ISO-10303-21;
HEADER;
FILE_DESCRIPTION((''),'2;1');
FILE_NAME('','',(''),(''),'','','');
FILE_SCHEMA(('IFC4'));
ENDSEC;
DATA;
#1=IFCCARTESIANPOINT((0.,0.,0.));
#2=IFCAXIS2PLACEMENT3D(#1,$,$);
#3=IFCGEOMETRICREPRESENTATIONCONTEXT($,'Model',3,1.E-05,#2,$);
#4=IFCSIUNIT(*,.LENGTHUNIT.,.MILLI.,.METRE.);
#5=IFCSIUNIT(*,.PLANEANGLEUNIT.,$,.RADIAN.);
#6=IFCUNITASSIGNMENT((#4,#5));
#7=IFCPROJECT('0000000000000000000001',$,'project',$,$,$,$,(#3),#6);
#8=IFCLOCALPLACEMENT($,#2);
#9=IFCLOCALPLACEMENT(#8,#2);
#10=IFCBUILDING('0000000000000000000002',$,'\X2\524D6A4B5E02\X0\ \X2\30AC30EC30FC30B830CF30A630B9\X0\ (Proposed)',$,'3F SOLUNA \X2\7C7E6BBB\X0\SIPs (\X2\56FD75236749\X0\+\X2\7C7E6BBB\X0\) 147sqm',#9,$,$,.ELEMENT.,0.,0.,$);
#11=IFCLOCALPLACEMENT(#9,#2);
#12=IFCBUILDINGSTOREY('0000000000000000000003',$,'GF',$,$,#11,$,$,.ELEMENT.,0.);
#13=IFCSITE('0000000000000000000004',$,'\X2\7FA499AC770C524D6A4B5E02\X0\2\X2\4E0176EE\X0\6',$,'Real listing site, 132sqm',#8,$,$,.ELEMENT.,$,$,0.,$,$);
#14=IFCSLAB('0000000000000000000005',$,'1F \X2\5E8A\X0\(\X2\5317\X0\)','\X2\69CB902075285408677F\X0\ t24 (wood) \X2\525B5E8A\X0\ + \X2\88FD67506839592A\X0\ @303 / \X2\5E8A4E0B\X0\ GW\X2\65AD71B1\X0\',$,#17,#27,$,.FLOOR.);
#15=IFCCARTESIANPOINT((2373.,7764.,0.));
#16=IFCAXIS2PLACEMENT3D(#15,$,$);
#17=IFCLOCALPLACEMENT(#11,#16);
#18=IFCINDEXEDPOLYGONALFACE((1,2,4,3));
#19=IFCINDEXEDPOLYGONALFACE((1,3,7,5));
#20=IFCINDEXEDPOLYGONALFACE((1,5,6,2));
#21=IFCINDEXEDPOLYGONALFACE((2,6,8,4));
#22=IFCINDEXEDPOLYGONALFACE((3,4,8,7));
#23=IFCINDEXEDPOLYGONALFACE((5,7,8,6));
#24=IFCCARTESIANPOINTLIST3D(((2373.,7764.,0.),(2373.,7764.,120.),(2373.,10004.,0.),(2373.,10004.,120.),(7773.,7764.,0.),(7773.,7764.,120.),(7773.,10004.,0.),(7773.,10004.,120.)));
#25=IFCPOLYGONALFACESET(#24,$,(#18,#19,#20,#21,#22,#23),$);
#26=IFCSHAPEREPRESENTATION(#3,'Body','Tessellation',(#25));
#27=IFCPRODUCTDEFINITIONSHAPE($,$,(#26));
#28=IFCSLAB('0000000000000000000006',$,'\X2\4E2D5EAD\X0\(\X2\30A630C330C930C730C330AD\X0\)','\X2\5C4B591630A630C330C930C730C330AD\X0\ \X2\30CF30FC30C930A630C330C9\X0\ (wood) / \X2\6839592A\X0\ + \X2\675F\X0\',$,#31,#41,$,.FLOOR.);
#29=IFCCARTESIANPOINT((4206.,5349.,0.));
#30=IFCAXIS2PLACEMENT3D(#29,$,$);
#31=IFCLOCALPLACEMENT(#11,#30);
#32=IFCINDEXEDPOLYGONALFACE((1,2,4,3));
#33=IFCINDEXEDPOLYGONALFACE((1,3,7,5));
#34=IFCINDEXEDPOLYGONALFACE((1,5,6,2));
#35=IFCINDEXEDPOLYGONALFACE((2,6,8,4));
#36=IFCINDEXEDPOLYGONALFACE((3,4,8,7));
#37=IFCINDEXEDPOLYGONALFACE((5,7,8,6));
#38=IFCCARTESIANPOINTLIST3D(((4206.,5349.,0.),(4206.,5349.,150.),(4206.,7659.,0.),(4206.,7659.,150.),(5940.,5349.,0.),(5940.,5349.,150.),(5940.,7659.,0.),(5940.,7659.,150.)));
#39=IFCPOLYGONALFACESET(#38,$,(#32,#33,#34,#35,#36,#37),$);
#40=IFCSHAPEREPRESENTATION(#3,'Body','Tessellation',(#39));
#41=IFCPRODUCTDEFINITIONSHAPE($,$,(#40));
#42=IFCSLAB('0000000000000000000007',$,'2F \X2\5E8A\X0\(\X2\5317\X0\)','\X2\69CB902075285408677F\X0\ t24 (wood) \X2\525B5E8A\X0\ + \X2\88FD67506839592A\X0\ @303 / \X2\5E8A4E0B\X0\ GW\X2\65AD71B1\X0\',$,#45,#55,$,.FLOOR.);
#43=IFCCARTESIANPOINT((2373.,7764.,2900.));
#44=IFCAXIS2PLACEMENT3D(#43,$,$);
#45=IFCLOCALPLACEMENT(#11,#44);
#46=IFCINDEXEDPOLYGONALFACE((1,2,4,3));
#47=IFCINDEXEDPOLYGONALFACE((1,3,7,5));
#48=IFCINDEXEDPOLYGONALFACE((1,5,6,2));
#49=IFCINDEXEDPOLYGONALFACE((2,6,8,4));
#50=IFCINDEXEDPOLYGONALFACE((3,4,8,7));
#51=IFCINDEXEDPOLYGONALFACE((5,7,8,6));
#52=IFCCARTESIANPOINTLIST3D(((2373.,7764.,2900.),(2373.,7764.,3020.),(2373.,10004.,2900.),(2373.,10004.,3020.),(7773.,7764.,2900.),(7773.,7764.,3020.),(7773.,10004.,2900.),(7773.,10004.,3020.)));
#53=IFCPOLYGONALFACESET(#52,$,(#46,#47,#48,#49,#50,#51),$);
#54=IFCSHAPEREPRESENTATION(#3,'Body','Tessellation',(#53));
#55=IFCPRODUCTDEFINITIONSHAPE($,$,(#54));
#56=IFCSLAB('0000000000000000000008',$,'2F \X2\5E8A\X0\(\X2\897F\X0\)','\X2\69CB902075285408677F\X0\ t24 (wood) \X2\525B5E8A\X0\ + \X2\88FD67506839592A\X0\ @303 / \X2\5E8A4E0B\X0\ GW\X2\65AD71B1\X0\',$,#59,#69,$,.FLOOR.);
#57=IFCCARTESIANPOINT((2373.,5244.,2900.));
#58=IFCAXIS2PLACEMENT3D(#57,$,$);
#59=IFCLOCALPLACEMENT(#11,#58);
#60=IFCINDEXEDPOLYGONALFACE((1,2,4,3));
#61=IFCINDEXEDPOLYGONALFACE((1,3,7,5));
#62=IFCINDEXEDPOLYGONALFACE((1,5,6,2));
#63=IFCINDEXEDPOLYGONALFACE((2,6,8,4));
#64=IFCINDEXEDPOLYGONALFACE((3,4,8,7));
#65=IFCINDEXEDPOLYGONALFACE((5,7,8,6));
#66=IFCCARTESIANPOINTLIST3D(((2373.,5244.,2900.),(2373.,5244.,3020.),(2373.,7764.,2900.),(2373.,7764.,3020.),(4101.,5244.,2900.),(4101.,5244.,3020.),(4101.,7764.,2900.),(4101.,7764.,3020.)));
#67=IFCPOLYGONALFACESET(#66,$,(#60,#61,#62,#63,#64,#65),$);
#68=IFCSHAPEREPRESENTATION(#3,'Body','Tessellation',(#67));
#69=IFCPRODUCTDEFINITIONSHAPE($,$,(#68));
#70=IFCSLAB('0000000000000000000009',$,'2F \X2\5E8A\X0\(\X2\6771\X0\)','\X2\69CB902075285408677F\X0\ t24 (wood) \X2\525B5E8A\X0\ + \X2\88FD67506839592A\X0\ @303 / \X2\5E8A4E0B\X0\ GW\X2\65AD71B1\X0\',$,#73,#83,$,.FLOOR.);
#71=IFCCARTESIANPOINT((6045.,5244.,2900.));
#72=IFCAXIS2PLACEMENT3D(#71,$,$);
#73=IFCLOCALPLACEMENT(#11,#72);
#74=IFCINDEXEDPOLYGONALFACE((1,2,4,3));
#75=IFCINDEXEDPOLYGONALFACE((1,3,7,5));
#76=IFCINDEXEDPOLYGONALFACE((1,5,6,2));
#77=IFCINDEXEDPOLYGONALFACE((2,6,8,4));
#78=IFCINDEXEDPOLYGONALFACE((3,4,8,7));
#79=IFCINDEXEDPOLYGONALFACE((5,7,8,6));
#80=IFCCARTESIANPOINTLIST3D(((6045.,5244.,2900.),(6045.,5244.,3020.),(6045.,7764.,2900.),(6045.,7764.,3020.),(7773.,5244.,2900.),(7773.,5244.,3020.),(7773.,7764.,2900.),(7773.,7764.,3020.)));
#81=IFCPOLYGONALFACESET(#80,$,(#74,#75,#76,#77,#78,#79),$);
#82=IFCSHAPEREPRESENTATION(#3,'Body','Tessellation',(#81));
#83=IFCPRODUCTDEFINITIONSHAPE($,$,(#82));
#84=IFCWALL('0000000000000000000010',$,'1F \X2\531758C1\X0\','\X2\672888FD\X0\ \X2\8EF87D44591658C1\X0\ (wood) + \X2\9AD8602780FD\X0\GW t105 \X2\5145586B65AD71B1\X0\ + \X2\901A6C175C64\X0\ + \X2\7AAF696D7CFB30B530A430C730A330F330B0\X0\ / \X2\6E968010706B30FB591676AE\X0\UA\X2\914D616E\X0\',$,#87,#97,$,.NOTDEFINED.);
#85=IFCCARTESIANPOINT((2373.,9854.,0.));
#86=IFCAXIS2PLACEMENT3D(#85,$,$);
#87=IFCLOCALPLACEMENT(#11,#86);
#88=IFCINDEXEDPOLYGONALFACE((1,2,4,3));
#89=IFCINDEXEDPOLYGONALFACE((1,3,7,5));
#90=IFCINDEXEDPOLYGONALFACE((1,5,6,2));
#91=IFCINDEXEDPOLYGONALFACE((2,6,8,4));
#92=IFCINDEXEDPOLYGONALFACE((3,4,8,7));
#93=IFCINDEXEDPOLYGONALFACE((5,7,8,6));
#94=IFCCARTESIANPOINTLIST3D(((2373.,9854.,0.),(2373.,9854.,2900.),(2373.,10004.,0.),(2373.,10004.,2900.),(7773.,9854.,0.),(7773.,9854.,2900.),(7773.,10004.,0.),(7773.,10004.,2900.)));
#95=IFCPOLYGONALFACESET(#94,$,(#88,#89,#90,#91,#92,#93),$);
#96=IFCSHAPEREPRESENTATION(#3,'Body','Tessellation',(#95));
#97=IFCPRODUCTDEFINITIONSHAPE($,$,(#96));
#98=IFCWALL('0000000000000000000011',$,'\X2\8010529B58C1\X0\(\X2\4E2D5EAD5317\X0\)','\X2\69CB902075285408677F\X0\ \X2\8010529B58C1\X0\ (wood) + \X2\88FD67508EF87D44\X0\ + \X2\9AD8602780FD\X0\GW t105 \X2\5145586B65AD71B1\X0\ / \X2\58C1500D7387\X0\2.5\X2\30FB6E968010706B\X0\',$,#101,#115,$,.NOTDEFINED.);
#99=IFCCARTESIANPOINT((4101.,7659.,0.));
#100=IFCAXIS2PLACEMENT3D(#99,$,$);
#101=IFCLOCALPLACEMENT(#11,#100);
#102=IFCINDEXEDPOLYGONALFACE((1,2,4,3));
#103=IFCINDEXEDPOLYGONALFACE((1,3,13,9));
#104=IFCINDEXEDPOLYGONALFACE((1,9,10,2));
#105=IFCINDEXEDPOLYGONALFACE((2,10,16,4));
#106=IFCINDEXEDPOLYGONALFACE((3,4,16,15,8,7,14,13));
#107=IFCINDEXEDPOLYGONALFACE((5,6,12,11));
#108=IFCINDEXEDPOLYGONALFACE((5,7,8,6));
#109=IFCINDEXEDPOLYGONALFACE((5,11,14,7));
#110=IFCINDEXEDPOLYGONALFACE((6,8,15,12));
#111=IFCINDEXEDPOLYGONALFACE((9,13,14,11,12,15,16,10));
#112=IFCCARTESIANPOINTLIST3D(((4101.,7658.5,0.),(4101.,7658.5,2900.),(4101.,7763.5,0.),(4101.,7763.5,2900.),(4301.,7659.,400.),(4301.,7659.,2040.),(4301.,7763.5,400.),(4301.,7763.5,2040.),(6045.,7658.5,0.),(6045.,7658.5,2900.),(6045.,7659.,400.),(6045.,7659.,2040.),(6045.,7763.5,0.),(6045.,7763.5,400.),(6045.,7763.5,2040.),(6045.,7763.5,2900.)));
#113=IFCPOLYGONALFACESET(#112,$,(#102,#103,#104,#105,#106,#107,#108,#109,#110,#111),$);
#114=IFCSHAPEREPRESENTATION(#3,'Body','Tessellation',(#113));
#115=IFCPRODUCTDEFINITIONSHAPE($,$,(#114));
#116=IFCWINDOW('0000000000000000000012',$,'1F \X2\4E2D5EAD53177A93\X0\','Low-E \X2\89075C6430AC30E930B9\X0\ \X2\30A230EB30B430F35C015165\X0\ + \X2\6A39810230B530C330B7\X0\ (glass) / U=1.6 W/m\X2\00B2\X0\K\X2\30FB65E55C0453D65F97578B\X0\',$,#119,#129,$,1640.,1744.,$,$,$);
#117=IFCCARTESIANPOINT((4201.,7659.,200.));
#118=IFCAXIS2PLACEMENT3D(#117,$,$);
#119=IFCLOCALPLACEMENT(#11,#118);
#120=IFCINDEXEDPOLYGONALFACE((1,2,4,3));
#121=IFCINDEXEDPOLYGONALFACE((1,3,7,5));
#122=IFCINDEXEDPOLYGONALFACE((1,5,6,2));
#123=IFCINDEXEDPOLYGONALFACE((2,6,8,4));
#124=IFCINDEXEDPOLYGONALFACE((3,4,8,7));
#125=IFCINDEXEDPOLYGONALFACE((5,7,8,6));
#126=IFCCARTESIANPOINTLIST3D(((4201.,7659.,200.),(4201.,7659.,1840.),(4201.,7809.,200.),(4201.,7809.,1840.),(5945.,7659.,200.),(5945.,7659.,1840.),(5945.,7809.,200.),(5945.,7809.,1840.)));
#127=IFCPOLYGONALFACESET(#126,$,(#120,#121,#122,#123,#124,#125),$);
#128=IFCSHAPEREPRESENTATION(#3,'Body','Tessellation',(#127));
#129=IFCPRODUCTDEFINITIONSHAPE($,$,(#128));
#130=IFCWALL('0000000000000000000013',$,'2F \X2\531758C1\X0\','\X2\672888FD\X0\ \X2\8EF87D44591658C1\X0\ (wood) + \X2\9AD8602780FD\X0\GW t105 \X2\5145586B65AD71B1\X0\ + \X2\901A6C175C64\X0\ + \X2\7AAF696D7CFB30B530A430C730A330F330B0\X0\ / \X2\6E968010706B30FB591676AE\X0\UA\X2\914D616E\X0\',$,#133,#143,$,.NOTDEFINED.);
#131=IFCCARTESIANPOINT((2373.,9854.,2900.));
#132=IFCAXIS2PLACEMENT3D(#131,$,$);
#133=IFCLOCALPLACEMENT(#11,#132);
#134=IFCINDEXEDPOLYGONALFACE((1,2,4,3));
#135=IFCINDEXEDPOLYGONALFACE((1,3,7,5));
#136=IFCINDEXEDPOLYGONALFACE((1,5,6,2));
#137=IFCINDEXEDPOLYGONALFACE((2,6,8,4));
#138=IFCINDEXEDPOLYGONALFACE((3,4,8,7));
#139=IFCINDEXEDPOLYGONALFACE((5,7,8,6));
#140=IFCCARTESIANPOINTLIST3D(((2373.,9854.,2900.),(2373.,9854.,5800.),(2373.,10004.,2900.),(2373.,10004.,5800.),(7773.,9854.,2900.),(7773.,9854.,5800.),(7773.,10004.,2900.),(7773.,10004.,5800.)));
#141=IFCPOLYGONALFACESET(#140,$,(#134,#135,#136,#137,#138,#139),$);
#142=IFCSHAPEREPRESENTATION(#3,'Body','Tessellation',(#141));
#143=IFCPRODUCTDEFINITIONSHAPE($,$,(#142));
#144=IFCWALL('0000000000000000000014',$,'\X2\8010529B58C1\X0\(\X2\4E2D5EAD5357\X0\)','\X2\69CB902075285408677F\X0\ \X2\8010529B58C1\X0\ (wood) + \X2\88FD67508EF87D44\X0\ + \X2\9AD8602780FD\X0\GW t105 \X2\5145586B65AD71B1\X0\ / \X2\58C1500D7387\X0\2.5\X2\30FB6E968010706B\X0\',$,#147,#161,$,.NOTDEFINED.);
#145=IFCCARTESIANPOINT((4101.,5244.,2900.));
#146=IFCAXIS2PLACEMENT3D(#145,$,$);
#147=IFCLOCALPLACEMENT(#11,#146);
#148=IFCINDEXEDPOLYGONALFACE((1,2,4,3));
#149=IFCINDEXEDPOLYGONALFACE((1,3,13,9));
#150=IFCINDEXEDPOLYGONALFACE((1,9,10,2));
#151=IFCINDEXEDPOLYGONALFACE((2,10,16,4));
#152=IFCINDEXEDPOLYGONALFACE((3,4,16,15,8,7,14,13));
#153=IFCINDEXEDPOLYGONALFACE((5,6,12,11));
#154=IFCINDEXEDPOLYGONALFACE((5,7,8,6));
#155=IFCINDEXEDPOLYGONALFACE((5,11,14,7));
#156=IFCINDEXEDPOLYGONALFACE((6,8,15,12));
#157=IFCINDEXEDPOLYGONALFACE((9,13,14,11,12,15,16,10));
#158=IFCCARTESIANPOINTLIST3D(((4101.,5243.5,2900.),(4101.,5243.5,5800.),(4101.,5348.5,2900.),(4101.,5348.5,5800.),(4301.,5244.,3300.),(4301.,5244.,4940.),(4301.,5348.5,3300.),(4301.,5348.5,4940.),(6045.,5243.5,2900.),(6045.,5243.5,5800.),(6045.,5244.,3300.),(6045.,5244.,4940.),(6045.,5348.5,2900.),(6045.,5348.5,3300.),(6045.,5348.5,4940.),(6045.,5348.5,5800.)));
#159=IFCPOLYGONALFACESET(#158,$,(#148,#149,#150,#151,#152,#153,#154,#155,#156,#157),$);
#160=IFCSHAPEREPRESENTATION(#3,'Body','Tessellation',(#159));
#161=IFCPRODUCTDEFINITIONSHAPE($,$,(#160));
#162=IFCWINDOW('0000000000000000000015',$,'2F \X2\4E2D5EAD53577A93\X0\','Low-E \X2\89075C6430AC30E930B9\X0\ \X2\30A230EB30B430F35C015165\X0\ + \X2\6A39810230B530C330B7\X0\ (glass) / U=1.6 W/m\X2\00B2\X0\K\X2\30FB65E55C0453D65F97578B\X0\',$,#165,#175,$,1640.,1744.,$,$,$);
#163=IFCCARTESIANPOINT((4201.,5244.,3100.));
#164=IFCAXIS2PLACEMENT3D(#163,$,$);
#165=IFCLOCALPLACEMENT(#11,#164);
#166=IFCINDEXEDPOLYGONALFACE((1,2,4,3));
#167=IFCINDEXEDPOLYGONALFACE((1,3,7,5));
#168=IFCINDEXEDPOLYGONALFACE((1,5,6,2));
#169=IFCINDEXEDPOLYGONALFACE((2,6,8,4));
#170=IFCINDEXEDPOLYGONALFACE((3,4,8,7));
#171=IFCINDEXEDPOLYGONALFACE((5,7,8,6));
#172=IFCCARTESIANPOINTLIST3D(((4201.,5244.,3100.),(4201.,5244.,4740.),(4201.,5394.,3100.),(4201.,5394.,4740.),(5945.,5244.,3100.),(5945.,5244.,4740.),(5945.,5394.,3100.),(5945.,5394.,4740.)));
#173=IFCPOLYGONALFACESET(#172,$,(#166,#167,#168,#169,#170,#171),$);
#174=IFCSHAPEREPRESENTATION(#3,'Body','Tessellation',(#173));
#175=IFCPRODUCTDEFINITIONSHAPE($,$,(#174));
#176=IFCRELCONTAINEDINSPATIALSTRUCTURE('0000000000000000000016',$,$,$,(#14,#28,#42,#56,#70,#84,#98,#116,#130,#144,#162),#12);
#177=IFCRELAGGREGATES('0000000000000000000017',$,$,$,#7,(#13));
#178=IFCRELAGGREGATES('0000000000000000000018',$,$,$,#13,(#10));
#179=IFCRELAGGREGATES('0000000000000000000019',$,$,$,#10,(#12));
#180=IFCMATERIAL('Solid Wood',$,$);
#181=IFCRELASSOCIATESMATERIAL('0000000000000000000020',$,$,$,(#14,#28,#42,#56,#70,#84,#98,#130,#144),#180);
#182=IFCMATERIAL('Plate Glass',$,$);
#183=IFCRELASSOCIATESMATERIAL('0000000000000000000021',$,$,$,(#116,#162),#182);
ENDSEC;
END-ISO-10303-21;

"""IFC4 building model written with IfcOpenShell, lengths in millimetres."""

from ifc_helpers import new_model, si_unit, frame, frame_2d, origin, place, context, project, spatial, rectangle, extrude, material, element, fill, save


model = new_model("IFC4")

# Units and contexts
model_context = context("Model", 3, precision=1e-05, world=origin())
ifc_project = project(units=[si_unit("LENGTHUNIT", "METRE", prefix="MILLI"), si_unit("PLANEANGLEUNIT", "RADIAN")], contexts=[model_context])

# Site, building, storey
site_placement = place(None, origin())
site = spatial("IfcSite", under=ifc_project, at=site_placement, Name="群馬県前橋市2丁目6", ObjectType="Real listing site, 132sqm", CompositionType="ELEMENT", RefElevation=0.0)
building_placement = place(site_placement, origin())
building = spatial("IfcBuilding", under=site, at=building_placement, Name="前橋市 ガレージハウス (Proposed)", ObjectType="3F SOLUNA 籾殻SIPs (国産杉+籾殻) 147sqm", CompositionType="ELEMENT", ElevationOfRefHeight=0.0, ElevationOfTerrain=0.0)
storey_placement = place(building_placement, origin())
storey = spatial("IfcBuildingStorey", under=building, at=storey_placement, Name="GF", CompositionType="ELEMENT", Elevation=0.0)

# Slabs
ifc_material_1 = material(Name="Solid Wood")
slab_1_placement = place(storey_placement, frame((2373.0, 7764.0, 0.0)))
element("IfcSlab", 1, at=slab_1_placement, inside=storey, material=ifc_material_1, Name="1F 床(北)", Description="構造用合板 t24 (wood) 剛床 + 製材根太 @303 / 床下 GW断熱", PredefinedType="FLOOR", context=model_context, shape_type="SweptSolid", body=[
    extrude(rectangle(XDim=5400.0, YDim=2240.0, at=frame_2d((2700.0, 1120.0))), frame((2373.0, 7764.0, 0.0)), (0.0, 0.0, 1.0), 120.0),
])
slab_2_placement = place(storey_placement, frame((4206.0, 5349.0, 0.0)))
element("IfcSlab", 2, at=slab_2_placement, inside=storey, material=ifc_material_1, Name="中庭(ウッドデッキ)", Description="屋外ウッドデッキ ハードウッド (wood) / 根太 + 束", PredefinedType="FLOOR", context=model_context, shape_type="SweptSolid", body=[
    extrude(rectangle(XDim=1734.0, YDim=2310.0, at=frame_2d((867.0, 1155.0))), frame((4206.0, 5349.0, 0.0)), (0.0, 0.0, 1.0), 150.0),
])
slab_3_placement = place(storey_placement, frame((2373.0, 7764.0, 2900.0)))
element("IfcSlab", 3, at=slab_3_placement, inside=storey, material=ifc_material_1, Name="2F 床(北)", Description="構造用合板 t24 (wood) 剛床 + 製材根太 @303 / 床下 GW断熱", PredefinedType="FLOOR", context=model_context, shape_type="SweptSolid", body=[
    extrude(rectangle(XDim=5400.0, YDim=2240.0, at=frame_2d((2700.0, 1120.0))), frame((2373.0, 7764.0, 2900.0)), (0.0, 0.0, 1.0), 120.0),
])
slab_4_placement = place(storey_placement, frame((2373.0, 5244.0, 2900.0)))
element("IfcSlab", 4, at=slab_4_placement, inside=storey, material=ifc_material_1, Name="2F 床(西)", Description="構造用合板 t24 (wood) 剛床 + 製材根太 @303 / 床下 GW断熱", PredefinedType="FLOOR", context=model_context, shape_type="SweptSolid", body=[
    extrude(rectangle(XDim=1728.0, YDim=2520.0, at=frame_2d((864.0, 1260.0))), frame((2373.0, 5244.0, 2900.0)), (0.0, 0.0, 1.0), 120.0),
])
slab_5_placement = place(storey_placement, frame((6045.0, 5244.0, 2900.0)))
element("IfcSlab", 5, at=slab_5_placement, inside=storey, material=ifc_material_1, Name="2F 床(東)", Description="構造用合板 t24 (wood) 剛床 + 製材根太 @303 / 床下 GW断熱", PredefinedType="FLOOR", context=model_context, shape_type="SweptSolid", body=[
    extrude(rectangle(XDim=1728.0, YDim=2520.0, at=frame_2d((864.0, 1260.0))), frame((6045.0, 5244.0, 2900.0)), (0.0, 0.0, 1.0), 120.0),
])

# Wall
wall_1_placement = place(storey_placement, frame((2373.0, 9854.0, 0.0)))
element("IfcWall", 6, at=wall_1_placement, inside=storey, material=ifc_material_1, Name="1F 北壁", Description="木製 軸組外壁 (wood) + 高性能GW t105 充填断熱 + 通気層 + 窯業系サイディング / 準耐火・外皮UA配慮", PredefinedType="NOTDEFINED", context=model_context, shape_type="SweptSolid", body=[
    extrude(rectangle(XDim=5400.0, YDim=150.0, at=frame_2d((2700.0, 75.0))), frame((2373.0, 9854.0, 0.0)), (0.0, 0.0, 1.0), 2900.0),
])

# Wall, opening, window
wall_2_placement = place(storey_placement, frame((4101.0, 7659.0, 0.0)))
wall_2 = element("IfcWall", 7, at=wall_2_placement, inside=storey, material=ifc_material_1, Name="耐力壁(中庭北)", Description="構造用合板 耐力壁 (wood) + 製材軸組 + 高性能GW t105 充填断熱 / 壁倍率2.5・準耐火", PredefinedType="NOTDEFINED", context=model_context, shape_type="SweptSolid", body=[
    extrude(rectangle(XDim=1944.0, YDim=105.0, at=frame_2d((972.0, 52.0))), frame((4101.0, 7659.0, 0.0)), (0.0, 0.0, 1.0), 2900.0),
])
opening_1_placement = place(storey_placement, frame((4201.0, 7659.0, 200.0)))
opening_1 = element("IfcOpeningElement", 8, at=opening_1_placement, cuts=wall_2, PredefinedType="NOTDEFINED", context=model_context, shape_type="SweptSolid", body=[
    extrude(rectangle(XDim=1744.0, YDim=150.0, at=frame_2d((872.0, 75.0))), frame((4201.0, 7659.0, 200.0)), (0.0, 0.0, 1.0), 1640.0),
])
ifc_material_2 = material(Name="Plate Glass")
window_1_placement = place(storey_placement, frame((4201.0, 7659.0, 200.0)))
window_1 = element("IfcWindow", 9, at=window_1_placement, inside=storey, material=ifc_material_2, Name="1F 中庭北窓", Description="Low-E 複層ガラス アルゴン封入 + 樹脂サッシ (glass) / U=1.6 W/m²K・日射取得型", OverallHeight=1640.0, OverallWidth=1744.0, context=model_context, shape_type="SweptSolid", body=[
    extrude(rectangle(XDim=1744.0, YDim=150.0, at=frame_2d((872.0, 75.0))), frame((4201.0, 7659.0, 200.0)), (0.0, 0.0, 1.0), 1640.0),
])
fill(opening_1, window_1)

# Wall
wall_3_placement = place(storey_placement, frame((2373.0, 9854.0, 2900.0)))
element("IfcWall", 10, at=wall_3_placement, inside=storey, material=ifc_material_1, Name="2F 北壁", Description="木製 軸組外壁 (wood) + 高性能GW t105 充填断熱 + 通気層 + 窯業系サイディング / 準耐火・外皮UA配慮", PredefinedType="NOTDEFINED", context=model_context, shape_type="SweptSolid", body=[
    extrude(rectangle(XDim=5400.0, YDim=150.0, at=frame_2d((2700.0, 75.0))), frame((2373.0, 9854.0, 2900.0)), (0.0, 0.0, 1.0), 2900.0),
])

# Wall, opening, window
wall_4_placement = place(storey_placement, frame((4101.0, 5244.0, 2900.0)))
wall_4 = element("IfcWall", 11, at=wall_4_placement, inside=storey, material=ifc_material_1, Name="耐力壁(中庭南)", Description="構造用合板 耐力壁 (wood) + 製材軸組 + 高性能GW t105 充填断熱 / 壁倍率2.5・準耐火", PredefinedType="NOTDEFINED", context=model_context, shape_type="SweptSolid", body=[
    extrude(rectangle(XDim=1944.0, YDim=105.0, at=frame_2d((972.0, 52.0))), frame((4101.0, 5244.0, 2900.0)), (0.0, 0.0, 1.0), 2900.0),
])
opening_2_placement = place(storey_placement, frame((4201.0, 5244.0, 3100.0)))
opening_2 = element("IfcOpeningElement", 12, at=opening_2_placement, cuts=wall_4, PredefinedType="NOTDEFINED", context=model_context, shape_type="SweptSolid", body=[
    extrude(rectangle(XDim=1744.0, YDim=150.0, at=frame_2d((872.0, 75.0))), frame((4201.0, 5244.0, 3100.0)), (0.0, 0.0, 1.0), 1640.0),
])
window_2_placement = place(storey_placement, frame((4201.0, 5244.0, 3100.0)))
window_2 = element("IfcWindow", 13, at=window_2_placement, inside=storey, material=ifc_material_2, Name="2F 中庭南窓", Description="Low-E 複層ガラス アルゴン封入 + 樹脂サッシ (glass) / U=1.6 W/m²K・日射取得型", OverallHeight=1640.0, OverallWidth=1744.0, context=model_context, shape_type="SweptSolid", body=[
    extrude(rectangle(XDim=1744.0, YDim=150.0, at=frame_2d((872.0, 75.0))), frame((4201.0, 5244.0, 3100.0)), (0.0, 0.0, 1.0), 1640.0),
])
fill(opening_2, window_2)

save(model, "model.ifc")
